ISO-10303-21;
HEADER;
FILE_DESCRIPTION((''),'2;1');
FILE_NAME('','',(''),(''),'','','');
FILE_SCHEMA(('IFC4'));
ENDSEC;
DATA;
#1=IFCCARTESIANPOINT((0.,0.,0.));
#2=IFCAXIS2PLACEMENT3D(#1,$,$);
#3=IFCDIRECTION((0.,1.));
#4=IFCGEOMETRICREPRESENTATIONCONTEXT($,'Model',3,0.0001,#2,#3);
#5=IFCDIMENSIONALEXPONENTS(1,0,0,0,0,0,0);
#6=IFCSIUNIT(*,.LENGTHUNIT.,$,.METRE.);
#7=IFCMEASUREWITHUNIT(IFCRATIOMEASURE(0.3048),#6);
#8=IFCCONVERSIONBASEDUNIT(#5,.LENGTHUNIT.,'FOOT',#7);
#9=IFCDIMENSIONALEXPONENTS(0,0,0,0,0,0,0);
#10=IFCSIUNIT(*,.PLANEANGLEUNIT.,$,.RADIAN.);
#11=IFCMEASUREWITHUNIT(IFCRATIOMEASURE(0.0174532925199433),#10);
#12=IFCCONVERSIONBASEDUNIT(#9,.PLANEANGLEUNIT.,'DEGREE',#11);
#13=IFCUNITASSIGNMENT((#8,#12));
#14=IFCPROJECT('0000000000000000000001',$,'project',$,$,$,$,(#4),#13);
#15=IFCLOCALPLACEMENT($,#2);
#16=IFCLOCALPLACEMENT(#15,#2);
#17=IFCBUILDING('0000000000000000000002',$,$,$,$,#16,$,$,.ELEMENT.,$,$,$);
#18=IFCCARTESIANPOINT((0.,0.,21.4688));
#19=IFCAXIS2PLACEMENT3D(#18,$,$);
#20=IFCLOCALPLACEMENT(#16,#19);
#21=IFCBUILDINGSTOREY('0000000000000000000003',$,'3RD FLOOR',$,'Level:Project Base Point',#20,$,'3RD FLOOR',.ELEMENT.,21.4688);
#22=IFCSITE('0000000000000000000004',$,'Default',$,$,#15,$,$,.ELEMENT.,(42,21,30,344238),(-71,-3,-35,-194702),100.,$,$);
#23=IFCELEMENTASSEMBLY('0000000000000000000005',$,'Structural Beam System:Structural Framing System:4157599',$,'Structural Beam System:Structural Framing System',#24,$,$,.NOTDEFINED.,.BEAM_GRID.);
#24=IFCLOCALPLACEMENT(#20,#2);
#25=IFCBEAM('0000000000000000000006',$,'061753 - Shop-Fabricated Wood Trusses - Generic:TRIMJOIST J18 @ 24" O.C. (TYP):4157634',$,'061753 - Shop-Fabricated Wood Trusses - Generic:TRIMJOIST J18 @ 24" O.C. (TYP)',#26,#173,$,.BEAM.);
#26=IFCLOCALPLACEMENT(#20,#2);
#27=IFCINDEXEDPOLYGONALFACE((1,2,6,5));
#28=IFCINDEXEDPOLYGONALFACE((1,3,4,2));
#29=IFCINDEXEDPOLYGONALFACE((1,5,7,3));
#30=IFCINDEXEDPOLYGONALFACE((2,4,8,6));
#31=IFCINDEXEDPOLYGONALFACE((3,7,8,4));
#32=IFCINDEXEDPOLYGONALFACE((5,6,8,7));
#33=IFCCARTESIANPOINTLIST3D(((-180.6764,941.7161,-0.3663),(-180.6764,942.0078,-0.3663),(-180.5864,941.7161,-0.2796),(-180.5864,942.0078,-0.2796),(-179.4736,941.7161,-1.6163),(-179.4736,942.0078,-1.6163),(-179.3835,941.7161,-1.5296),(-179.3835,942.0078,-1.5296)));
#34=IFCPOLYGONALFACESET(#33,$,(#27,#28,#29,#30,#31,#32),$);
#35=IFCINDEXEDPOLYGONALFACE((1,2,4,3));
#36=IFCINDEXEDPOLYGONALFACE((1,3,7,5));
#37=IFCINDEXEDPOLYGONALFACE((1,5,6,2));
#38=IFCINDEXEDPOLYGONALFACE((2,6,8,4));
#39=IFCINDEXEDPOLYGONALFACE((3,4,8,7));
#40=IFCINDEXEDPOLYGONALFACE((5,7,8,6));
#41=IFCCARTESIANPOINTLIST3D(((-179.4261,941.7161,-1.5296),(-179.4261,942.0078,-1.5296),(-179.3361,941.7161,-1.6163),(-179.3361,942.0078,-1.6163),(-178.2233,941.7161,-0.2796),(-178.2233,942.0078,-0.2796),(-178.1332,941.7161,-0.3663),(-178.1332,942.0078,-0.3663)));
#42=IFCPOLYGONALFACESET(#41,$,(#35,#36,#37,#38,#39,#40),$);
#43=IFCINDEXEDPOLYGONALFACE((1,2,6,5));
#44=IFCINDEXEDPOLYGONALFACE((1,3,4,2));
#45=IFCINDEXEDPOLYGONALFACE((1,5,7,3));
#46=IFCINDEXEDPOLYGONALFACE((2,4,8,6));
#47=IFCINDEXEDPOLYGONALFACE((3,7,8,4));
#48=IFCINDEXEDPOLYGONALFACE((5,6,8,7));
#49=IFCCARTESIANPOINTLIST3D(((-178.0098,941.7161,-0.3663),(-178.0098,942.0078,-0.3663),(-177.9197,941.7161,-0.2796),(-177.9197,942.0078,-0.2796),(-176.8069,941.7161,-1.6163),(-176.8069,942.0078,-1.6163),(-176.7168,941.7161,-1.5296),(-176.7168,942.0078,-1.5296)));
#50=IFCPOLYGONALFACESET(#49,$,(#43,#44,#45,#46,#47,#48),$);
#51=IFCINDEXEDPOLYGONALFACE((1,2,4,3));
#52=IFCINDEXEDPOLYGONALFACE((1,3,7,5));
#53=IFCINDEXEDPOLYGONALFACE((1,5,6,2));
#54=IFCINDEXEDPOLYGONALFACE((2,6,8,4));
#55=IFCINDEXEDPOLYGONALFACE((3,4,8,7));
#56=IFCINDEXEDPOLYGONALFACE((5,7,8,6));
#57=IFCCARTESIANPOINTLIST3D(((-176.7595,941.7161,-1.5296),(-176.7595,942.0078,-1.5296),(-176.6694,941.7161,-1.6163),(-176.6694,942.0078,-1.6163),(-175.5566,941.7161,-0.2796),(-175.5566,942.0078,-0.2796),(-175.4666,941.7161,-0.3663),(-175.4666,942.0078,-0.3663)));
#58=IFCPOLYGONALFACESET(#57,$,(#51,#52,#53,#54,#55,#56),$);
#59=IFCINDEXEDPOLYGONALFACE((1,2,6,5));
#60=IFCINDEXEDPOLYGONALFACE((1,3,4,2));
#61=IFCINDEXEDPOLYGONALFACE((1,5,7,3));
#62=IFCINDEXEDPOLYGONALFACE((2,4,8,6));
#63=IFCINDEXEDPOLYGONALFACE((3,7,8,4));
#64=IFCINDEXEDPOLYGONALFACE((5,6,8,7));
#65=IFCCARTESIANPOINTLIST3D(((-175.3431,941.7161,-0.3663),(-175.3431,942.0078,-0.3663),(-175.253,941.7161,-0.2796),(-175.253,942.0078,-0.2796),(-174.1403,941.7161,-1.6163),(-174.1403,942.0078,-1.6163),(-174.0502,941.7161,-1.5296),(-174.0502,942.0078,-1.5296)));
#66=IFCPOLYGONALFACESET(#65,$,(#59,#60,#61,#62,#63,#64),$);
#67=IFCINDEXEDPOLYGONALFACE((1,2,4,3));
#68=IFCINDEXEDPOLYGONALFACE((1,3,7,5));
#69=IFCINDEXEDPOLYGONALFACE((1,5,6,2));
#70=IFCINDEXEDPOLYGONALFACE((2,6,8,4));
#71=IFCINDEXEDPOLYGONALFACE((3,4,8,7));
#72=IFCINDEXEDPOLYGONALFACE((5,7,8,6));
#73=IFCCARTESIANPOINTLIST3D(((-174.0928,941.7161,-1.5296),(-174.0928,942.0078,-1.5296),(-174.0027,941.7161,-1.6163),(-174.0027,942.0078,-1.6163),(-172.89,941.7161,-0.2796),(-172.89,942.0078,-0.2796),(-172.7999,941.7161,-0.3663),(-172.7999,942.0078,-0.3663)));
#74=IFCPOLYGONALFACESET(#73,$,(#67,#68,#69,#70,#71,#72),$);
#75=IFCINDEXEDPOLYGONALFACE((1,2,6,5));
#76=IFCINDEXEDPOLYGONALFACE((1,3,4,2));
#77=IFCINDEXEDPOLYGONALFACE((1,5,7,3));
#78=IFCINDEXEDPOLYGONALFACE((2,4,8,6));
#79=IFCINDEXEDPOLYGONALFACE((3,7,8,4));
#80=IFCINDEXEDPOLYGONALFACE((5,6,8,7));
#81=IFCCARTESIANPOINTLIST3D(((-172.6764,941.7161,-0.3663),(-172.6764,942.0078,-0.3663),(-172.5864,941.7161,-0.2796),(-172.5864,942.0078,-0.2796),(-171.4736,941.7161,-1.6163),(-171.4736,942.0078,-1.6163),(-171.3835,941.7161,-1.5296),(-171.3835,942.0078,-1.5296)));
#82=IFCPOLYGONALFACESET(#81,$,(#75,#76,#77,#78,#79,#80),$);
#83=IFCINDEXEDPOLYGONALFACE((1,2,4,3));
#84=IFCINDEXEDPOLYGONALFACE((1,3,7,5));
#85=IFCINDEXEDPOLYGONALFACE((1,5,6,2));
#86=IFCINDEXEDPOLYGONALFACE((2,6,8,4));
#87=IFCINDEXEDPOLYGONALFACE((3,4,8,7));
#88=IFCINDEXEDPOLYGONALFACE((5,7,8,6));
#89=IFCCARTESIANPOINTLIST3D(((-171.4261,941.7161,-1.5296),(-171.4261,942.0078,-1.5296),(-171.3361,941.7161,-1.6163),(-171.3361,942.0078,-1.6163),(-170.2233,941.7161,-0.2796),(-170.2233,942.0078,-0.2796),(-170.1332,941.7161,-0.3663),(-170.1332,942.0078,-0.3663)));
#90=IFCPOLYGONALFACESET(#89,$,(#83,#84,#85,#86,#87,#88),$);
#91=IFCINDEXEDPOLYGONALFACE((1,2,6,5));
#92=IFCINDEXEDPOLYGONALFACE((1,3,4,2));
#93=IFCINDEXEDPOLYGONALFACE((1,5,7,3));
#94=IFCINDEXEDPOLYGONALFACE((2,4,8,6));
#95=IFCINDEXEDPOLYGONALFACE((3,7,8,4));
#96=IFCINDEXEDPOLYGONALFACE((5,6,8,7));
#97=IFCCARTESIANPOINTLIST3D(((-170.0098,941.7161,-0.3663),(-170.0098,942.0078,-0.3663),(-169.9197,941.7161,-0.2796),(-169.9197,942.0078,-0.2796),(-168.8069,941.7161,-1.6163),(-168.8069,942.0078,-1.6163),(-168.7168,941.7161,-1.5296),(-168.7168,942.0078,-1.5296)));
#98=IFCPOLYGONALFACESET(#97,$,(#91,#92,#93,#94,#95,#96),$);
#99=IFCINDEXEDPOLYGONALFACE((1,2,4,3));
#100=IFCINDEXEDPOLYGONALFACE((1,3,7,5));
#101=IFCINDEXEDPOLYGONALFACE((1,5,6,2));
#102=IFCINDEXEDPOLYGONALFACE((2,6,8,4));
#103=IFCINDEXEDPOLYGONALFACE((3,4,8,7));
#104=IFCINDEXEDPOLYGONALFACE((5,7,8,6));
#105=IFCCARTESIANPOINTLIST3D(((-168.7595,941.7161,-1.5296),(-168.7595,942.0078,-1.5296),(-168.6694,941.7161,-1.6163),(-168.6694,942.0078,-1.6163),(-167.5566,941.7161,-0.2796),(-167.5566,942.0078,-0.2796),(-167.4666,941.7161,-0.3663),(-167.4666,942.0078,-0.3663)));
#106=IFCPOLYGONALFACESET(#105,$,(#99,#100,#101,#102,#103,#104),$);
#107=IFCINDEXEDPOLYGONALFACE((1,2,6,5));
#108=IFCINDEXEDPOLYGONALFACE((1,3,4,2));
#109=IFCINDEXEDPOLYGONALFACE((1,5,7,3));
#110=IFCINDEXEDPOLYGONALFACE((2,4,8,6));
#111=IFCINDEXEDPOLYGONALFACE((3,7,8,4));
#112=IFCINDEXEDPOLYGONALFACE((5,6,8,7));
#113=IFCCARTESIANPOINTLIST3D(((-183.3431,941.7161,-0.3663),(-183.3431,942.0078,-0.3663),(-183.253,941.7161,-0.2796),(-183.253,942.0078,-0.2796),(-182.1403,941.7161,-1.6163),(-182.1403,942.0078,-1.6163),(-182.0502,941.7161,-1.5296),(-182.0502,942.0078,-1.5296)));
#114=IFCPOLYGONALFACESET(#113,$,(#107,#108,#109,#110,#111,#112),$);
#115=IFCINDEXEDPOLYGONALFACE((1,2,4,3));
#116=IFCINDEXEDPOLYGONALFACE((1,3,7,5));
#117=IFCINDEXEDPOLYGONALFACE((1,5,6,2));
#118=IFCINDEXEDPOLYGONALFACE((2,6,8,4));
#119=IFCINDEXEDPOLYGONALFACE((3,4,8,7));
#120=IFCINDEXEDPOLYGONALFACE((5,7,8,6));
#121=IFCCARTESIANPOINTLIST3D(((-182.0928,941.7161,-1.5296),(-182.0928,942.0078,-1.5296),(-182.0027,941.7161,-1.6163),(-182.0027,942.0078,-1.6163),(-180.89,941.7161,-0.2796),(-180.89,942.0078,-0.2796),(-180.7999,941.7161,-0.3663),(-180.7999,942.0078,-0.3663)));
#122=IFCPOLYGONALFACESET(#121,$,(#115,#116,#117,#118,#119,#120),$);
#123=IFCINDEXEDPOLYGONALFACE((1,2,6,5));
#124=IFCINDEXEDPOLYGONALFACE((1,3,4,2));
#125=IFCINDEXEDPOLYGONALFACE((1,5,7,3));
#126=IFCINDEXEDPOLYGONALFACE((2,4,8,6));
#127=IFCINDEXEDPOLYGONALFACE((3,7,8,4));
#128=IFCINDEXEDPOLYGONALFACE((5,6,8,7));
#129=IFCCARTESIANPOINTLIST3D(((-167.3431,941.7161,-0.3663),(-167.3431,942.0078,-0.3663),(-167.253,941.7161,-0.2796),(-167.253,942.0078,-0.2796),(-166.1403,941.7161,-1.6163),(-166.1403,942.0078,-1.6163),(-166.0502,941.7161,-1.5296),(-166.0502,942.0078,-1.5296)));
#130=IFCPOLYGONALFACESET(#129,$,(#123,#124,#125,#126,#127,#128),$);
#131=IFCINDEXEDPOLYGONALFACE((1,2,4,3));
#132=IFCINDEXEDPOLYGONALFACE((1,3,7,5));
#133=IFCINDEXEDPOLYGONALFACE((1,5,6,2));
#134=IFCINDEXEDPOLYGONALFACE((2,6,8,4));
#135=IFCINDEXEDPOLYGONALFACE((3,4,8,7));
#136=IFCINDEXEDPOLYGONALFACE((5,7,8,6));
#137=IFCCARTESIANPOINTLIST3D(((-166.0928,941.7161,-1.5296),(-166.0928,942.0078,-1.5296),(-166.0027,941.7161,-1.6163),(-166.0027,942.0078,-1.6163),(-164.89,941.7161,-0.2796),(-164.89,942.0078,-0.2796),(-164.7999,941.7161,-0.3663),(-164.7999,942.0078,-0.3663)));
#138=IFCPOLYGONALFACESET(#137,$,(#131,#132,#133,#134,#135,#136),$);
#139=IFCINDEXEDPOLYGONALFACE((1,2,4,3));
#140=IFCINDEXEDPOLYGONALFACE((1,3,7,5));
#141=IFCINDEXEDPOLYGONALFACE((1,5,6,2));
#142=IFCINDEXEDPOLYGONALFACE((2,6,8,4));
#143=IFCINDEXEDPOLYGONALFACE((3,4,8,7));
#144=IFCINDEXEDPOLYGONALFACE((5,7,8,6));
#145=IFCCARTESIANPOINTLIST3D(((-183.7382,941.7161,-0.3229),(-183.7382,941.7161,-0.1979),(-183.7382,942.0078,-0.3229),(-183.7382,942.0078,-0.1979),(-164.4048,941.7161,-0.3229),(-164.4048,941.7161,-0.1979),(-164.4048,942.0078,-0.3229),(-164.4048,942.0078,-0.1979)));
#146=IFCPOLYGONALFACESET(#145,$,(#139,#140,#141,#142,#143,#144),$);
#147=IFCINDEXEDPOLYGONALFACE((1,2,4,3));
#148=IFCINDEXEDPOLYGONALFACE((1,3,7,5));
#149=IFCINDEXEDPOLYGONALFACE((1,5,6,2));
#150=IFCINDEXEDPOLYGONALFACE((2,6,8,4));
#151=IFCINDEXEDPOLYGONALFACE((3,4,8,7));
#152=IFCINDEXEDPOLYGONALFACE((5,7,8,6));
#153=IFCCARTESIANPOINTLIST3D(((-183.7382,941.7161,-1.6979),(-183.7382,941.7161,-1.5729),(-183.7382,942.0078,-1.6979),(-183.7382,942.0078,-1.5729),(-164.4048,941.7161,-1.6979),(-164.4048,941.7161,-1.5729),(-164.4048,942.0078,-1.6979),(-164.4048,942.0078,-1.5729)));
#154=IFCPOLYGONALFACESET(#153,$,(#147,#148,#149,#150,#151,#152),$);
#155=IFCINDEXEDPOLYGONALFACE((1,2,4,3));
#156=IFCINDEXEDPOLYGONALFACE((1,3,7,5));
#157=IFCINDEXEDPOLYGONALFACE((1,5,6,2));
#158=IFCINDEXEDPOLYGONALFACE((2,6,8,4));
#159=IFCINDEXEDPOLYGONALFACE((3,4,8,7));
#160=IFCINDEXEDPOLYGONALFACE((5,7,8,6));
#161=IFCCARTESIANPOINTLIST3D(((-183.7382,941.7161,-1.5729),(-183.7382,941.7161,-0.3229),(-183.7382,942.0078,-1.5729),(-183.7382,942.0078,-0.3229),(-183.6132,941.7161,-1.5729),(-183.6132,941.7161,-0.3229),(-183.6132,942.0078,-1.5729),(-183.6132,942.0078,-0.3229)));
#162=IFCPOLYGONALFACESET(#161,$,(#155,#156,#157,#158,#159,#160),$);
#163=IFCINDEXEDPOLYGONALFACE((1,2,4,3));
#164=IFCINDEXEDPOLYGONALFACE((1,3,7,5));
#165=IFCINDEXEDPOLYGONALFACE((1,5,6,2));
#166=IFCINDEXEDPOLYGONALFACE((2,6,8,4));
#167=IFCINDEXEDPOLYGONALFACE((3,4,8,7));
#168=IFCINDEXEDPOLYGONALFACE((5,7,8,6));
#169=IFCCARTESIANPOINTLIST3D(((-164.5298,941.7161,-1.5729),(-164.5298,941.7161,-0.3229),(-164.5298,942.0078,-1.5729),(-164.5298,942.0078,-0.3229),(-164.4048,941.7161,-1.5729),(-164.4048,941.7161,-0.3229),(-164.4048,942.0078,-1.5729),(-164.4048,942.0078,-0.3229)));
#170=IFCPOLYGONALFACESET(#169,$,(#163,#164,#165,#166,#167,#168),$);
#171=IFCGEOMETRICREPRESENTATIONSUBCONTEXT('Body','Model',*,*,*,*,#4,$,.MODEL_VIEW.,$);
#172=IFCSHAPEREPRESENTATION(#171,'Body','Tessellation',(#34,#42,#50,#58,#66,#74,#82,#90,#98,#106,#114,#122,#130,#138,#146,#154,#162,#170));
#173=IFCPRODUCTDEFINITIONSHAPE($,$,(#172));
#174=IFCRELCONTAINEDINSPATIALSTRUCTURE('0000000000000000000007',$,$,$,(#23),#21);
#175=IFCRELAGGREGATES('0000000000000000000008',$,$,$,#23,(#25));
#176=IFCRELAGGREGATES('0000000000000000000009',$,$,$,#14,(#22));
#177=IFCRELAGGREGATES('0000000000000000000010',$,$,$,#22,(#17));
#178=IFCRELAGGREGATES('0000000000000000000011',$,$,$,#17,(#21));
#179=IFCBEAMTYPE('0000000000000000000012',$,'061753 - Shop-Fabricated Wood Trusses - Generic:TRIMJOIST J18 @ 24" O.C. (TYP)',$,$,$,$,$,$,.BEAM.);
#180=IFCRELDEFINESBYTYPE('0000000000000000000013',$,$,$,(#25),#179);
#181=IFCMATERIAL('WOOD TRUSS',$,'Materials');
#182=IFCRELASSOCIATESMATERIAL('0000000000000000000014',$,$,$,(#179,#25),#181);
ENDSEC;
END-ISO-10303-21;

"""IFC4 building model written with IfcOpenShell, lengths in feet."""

from ifc_helpers import new_model, entity, si_unit, converted_unit, direction, frame, frame_2d, origin, origin_2d_with_axis, place, context, subcontext, project, spatial, rectangle, extrude, source, transform, mapped, material, material_profile, profile_set, profile_usage, type_object, type_shapes, element, aggregate, save


model = new_model("IFC4")

# Units and contexts
model_context = context("Model", 3, precision=0.0001, world=origin(), true_north=direction((0.0, 1.0)))
body_context = subcontext(model_context, "Body", "Model", "MODEL_VIEW")
ifc_project = project(units=[converted_unit("LENGTHUNIT", "FOOT", entity("IfcRatioMeasure", 0.3048), si_unit("LENGTHUNIT", "METRE"), dimensions=[1, 0, 0, 0, 0, 0, 0]), converted_unit("PLANEANGLEUNIT", "DEGREE", entity("IfcRatioMeasure", 0.0174532925199433), si_unit("PLANEANGLEUNIT", "RADIAN"), dimensions=[0, 0, 0, 0, 0, 0, 0])], contexts=[model_context])

# Site, building, storey
site_placement = place(None, origin())
site = spatial("IfcSite", under=ifc_project, at=site_placement, Name="Default", CompositionType="ELEMENT", RefLatitude=(42, 21, 30, 344238), RefLongitude=(-71, -3, -35, -194702), RefElevation=100.0)
building_placement = place(site_placement, origin())
building = spatial("IfcBuilding", under=site, at=building_placement, CompositionType="ELEMENT")
storey_placement = place(building_placement, frame((0.0, 0.0, 21.4688)))
storey = spatial("IfcBuildingStorey", under=building, at=storey_placement, Name="3RD FLOOR", ObjectType="Level:Project Base Point", LongName="3RD FLOOR", CompositionType="ELEMENT", Elevation=21.4688)

# Element assembly, beam
ifc_material = material(Name="WOOD TRUSS", Category="Materials")
ifc_material_profile_1 = material_profile(ifc_material, rectangle(XDim=1.7347, YDim=0.125, at=frame_2d((0.0, 0.0), x_axis=(1.0, 0.0))), Name="TRIMJOIST J18 @ 24\" O.C. (TYP)")
ifc_material_profile_2 = material_profile(ifc_material, rectangle(XDim=1.7347, YDim=0.125, at=frame_2d((0.0, 0.0), x_axis=(1.0, 0.0))), Name="TRIMJOIST J18 @ 24\" O.C. (TYP)")
ifc_material_profile_3 = material_profile(ifc_material, rectangle(XDim=1.7347, YDim=0.125, at=frame_2d((0.0, 0.0), x_axis=(1.0, 0.0))), Name="TRIMJOIST J18 @ 24\" O.C. (TYP)")
ifc_material_profile_4 = material_profile(ifc_material, rectangle(XDim=1.7347, YDim=0.125, at=frame_2d((0.0, 0.0), x_axis=(1.0, 0.0))), Name="TRIMJOIST J18 @ 24\" O.C. (TYP)")
ifc_material_profile_5 = material_profile(ifc_material, rectangle(XDim=1.7347, YDim=0.125, at=frame_2d((0.0, 0.0), x_axis=(1.0, 0.0))), Name="TRIMJOIST J18 @ 24\" O.C. (TYP)")
ifc_material_profile_6 = material_profile(ifc_material, rectangle(XDim=1.7347, YDim=0.125, at=frame_2d((0.0, 0.0), x_axis=(1.0, 0.0))), Name="TRIMJOIST J18 @ 24\" O.C. (TYP)")
ifc_material_profile_7 = material_profile(ifc_material, rectangle(XDim=1.7347, YDim=0.125, at=frame_2d((0.0, 0.0), x_axis=(1.0, 0.0))), Name="TRIMJOIST J18 @ 24\" O.C. (TYP)")
ifc_material_profile_8 = material_profile(ifc_material, rectangle(XDim=1.7347, YDim=0.125, at=frame_2d((0.0, 0.0), x_axis=(1.0, 0.0))), Name="TRIMJOIST J18 @ 24\" O.C. (TYP)")
ifc_material_profile_9 = material_profile(ifc_material, rectangle(XDim=1.7347, YDim=0.125, at=frame_2d((0.0, 0.0), x_axis=(1.0, 0.0))), Name="TRIMJOIST J18 @ 24\" O.C. (TYP)")
ifc_material_profile_10 = material_profile(ifc_material, rectangle(XDim=1.7347, YDim=0.125, at=origin_2d_with_axis()), Name="TRIMJOIST J18 @ 24\" O.C. (TYP)")
ifc_material_profile_11 = material_profile(ifc_material, rectangle(XDim=0.125, YDim=0.2917, at=origin_2d_with_axis()), Name="TRIMJOIST J18 @ 24\" O.C. (TYP)")
ifc_material_profile_12 = material_profile(ifc_material, rectangle(XDim=0.125, YDim=0.2917, at=origin_2d_with_axis()), Name="TRIMJOIST J18 @ 24\" O.C. (TYP)")
ifc_material_profile_13 = material_profile(ifc_material, rectangle(XDim=1.25, YDim=0.2917, at=origin_2d_with_axis()), Name="TRIMJOIST J18 @ 24\" O.C. (TYP)")
ifc_material_profile_14 = material_profile(ifc_material, rectangle(XDim=1.25, YDim=0.2917, at=origin_2d_with_axis()), Name="TRIMJOIST J18 @ 24\" O.C. (TYP)")
ifc_profile_set = profile_set([ifc_material_profile_1, ifc_material_profile_2, ifc_material_profile_3, ifc_material_profile_4, ifc_material_profile_5, ifc_material_profile_6, ifc_material_profile_7, ifc_material_profile_8, ifc_material_profile_9, ifc_material_profile_10, ifc_material_profile_11, ifc_material_profile_12, ifc_material_profile_13, ifc_material_profile_14], Name="TRIMJOIST J18 @ 24\" O.C. (TYP)")
assembly_1_placement = place(storey_placement, origin())
assembly_1 = element("IfcElementAssembly", 1, at=assembly_1_placement, inside=storey, Name="Structural Beam System:Structural Framing System:4157599", ObjectType="Structural Beam System:Structural Framing System", AssemblyPlace="NOTDEFINED", PredefinedType="BEAM_GRID")
beam_type_1 = type_object("IfcBeamType", Name="061753 - Shop-Fabricated Wood Trusses - Generic:TRIMJOIST J18 @ 24\" O.C. (TYP)", PredefinedType="BEAM", material=ifc_profile_set)
shared_shape_1 = source(origin(), body_context, "Body", "SweptSolid", [
    extrude(rectangle(XDim=1.7347, YDim=0.125, at=frame_2d((0.0, 0.0), x_axis=(1.0, 0.0))), frame((5.9585, -0.1458, 0.0), z_axis=(0.0, 1.0, 0.0), x_axis=(0.693383, 0.0, 0.720569)), (0.0, 0.0, 1.0), 0.2917),
    extrude(rectangle(XDim=1.7347, YDim=0.125, at=origin_2d_with_axis()), frame((4.7082, -0.1458, 0.0), z_axis=(0.0, 1.0, 0.0), x_axis=(0.693383, 0.0, -0.720569)), (0.0, 0.0, 1.0), 0.2917),
    extrude(rectangle(XDim=1.7347, YDim=0.125, at=frame_2d((0.0, 0.0), x_axis=(1.0, 0.0))), frame((3.2918, -0.1458, 0.0), z_axis=(0.0, 1.0, 0.0), x_axis=(0.693383, 0.0, 0.720569)), (0.0, 0.0, 1.0), 0.2917),
    extrude(rectangle(XDim=1.7347, YDim=0.125, at=frame_2d((0.0, 0.0), x_axis=(1.0, 0.0))), frame((2.0415, -0.1458, 0.0), z_axis=(0.0, 1.0, 0.0), x_axis=(0.693383, 0.0, -0.720569)), (0.0, 0.0, 1.0), 0.2917),
    extrude(rectangle(XDim=1.7347, YDim=0.125, at=frame_2d((0.0, 0.0), x_axis=(1.0, 0.0))), frame((0.6251, -0.1458, 0.0), z_axis=(0.0, 1.0, 0.0), x_axis=(0.693383, 0.0, 0.720569)), (0.0, 0.0, 1.0), 0.2917),
    extrude(rectangle(XDim=1.7347, YDim=0.125, at=frame_2d((0.0, 0.0), x_axis=(1.0, 0.0))), frame((-0.6251, -0.1458, 0.0), z_axis=(0.0, 1.0, 0.0), x_axis=(0.693383, 0.0, -0.720569)), (0.0, 0.0, 1.0), 0.2917),
    extrude(rectangle(XDim=1.7347, YDim=0.125, at=frame_2d((0.0, 0.0), x_axis=(1.0, 0.0))), frame((-2.0415, -0.1458, 0.0), z_axis=(0.0, 1.0, 0.0), x_axis=(0.693383, 0.0, 0.720569)), (0.0, 0.0, 1.0), 0.2917),
    extrude(rectangle(XDim=1.7347, YDim=0.125, at=origin_2d_with_axis()), frame((-3.2918, -0.1458, 0.0), z_axis=(0.0, 1.0, 0.0), x_axis=(0.693383, 0.0, -0.720569)), (0.0, 0.0, 1.0), 0.2917),
    extrude(rectangle(XDim=1.7347, YDim=0.125, at=frame_2d((0.0, 0.0), x_axis=(1.0, 0.0))), frame((-4.7082, -0.1458, 0.0), z_axis=(0.0, 1.0, 0.0), x_axis=(0.693383, 0.0, 0.720569)), (0.0, 0.0, 1.0), 0.2917),
    extrude(rectangle(XDim=1.7347, YDim=0.125, at=frame_2d((0.0, 0.0), x_axis=(1.0, 0.0))), frame((-5.9585, -0.1458, 0.0), z_axis=(0.0, 1.0, 0.0), x_axis=(0.693383, 0.0, -0.720569)), (0.0, 0.0, 1.0), 0.2917),
    extrude(rectangle(XDim=1.7347, YDim=0.125, at=frame_2d((0.0, 0.0), x_axis=(1.0, 0.0))), frame((8.6251, -0.1458, 0.0), z_axis=(0.0, 1.0, 0.0), x_axis=(0.693383, 0.0, 0.720569)), (0.0, 0.0, 1.0), 0.2917),
    extrude(rectangle(XDim=1.7347, YDim=0.125, at=origin_2d_with_axis()), frame((7.3749, -0.1458, 0.0), z_axis=(0.0, 1.0, 0.0), x_axis=(0.693383, 0.0, -0.720569)), (0.0, 0.0, 1.0), 0.2917),
    extrude(rectangle(XDim=1.7347, YDim=0.125, at=frame_2d((0.0, 0.0), x_axis=(1.0, 0.0))), frame((-7.3749, -0.1458, 0.0), z_axis=(0.0, 1.0, 0.0), x_axis=(0.693383, 0.0, 0.720569)), (0.0, 0.0, 1.0), 0.2917),
    extrude(rectangle(XDim=1.7347, YDim=0.125, at=origin_2d_with_axis()), frame((-8.6251, -0.1458, 0.0), z_axis=(0.0, 1.0, 0.0), x_axis=(0.693383, 0.0, -0.720569)), (0.0, 0.0, 1.0), 0.2917),
    extrude(rectangle(XDim=0.125, YDim=0.2917, at=origin_2d_with_axis()), frame((-9.6667, 0.0, 0.6875), z_axis=(1.0, 0.0, 0.0), x_axis=(0.0, 0.0, -1.0)), (0.0, 0.0, 1.0), 19.3333),
    extrude(rectangle(XDim=0.125, YDim=0.2917, at=origin_2d_with_axis()), frame((-9.6667, 0.0, -0.6875), z_axis=(1.0, 0.0, 0.0), x_axis=(0.0, 0.0, -1.0)), (0.0, 0.0, 1.0), 19.3333),
    extrude(rectangle(XDim=1.25, YDim=0.2917, at=origin_2d_with_axis()), frame((9.5417, 0.0, 0.0), z_axis=(1.0, 0.0, 0.0), x_axis=(0.0, 0.0, -1.0)), (0.0, 0.0, 1.0), 0.125),
    extrude(rectangle(XDim=1.25, YDim=0.2917, at=origin_2d_with_axis()), frame((-9.6667, 0.0, 0.0), z_axis=(1.0, 0.0, 0.0), x_axis=(0.0, 0.0, -1.0)), (0.0, 0.0, 1.0), 0.125),
])
type_shapes(beam_type_1, [shared_shape_1])
ifc_profile_usage_1 = profile_usage(ifc_profile_set, cardinal=8)
beam_1_placement = place(assembly_1_placement, frame((-174.0715, 941.8619, -0.9479), z_axis=(0.0, 0.0, 1.0), x_axis=(-1.0, 0.0, 0.0)))
beam_1 = element("IfcBeam", 2, at=beam_1_placement, type_object=beam_type_1, material=ifc_profile_usage_1, Name="061753 - Shop-Fabricated Wood Trusses - Generic:TRIMJOIST J18 @ 24\" O.C. (TYP):4157634", ObjectType="061753 - Shop-Fabricated Wood Trusses - Generic:TRIMJOIST J18 @ 24\" O.C. (TYP)", PredefinedType="BEAM", context=body_context, shape_type="MappedRepresentation", body=[
    mapped(shared_shape_1, transform((0.0, 0.0, 0.0), scale=1.0)),
])
aggregate(assembly_1, [beam_1])

save(model, "model.ifc")
